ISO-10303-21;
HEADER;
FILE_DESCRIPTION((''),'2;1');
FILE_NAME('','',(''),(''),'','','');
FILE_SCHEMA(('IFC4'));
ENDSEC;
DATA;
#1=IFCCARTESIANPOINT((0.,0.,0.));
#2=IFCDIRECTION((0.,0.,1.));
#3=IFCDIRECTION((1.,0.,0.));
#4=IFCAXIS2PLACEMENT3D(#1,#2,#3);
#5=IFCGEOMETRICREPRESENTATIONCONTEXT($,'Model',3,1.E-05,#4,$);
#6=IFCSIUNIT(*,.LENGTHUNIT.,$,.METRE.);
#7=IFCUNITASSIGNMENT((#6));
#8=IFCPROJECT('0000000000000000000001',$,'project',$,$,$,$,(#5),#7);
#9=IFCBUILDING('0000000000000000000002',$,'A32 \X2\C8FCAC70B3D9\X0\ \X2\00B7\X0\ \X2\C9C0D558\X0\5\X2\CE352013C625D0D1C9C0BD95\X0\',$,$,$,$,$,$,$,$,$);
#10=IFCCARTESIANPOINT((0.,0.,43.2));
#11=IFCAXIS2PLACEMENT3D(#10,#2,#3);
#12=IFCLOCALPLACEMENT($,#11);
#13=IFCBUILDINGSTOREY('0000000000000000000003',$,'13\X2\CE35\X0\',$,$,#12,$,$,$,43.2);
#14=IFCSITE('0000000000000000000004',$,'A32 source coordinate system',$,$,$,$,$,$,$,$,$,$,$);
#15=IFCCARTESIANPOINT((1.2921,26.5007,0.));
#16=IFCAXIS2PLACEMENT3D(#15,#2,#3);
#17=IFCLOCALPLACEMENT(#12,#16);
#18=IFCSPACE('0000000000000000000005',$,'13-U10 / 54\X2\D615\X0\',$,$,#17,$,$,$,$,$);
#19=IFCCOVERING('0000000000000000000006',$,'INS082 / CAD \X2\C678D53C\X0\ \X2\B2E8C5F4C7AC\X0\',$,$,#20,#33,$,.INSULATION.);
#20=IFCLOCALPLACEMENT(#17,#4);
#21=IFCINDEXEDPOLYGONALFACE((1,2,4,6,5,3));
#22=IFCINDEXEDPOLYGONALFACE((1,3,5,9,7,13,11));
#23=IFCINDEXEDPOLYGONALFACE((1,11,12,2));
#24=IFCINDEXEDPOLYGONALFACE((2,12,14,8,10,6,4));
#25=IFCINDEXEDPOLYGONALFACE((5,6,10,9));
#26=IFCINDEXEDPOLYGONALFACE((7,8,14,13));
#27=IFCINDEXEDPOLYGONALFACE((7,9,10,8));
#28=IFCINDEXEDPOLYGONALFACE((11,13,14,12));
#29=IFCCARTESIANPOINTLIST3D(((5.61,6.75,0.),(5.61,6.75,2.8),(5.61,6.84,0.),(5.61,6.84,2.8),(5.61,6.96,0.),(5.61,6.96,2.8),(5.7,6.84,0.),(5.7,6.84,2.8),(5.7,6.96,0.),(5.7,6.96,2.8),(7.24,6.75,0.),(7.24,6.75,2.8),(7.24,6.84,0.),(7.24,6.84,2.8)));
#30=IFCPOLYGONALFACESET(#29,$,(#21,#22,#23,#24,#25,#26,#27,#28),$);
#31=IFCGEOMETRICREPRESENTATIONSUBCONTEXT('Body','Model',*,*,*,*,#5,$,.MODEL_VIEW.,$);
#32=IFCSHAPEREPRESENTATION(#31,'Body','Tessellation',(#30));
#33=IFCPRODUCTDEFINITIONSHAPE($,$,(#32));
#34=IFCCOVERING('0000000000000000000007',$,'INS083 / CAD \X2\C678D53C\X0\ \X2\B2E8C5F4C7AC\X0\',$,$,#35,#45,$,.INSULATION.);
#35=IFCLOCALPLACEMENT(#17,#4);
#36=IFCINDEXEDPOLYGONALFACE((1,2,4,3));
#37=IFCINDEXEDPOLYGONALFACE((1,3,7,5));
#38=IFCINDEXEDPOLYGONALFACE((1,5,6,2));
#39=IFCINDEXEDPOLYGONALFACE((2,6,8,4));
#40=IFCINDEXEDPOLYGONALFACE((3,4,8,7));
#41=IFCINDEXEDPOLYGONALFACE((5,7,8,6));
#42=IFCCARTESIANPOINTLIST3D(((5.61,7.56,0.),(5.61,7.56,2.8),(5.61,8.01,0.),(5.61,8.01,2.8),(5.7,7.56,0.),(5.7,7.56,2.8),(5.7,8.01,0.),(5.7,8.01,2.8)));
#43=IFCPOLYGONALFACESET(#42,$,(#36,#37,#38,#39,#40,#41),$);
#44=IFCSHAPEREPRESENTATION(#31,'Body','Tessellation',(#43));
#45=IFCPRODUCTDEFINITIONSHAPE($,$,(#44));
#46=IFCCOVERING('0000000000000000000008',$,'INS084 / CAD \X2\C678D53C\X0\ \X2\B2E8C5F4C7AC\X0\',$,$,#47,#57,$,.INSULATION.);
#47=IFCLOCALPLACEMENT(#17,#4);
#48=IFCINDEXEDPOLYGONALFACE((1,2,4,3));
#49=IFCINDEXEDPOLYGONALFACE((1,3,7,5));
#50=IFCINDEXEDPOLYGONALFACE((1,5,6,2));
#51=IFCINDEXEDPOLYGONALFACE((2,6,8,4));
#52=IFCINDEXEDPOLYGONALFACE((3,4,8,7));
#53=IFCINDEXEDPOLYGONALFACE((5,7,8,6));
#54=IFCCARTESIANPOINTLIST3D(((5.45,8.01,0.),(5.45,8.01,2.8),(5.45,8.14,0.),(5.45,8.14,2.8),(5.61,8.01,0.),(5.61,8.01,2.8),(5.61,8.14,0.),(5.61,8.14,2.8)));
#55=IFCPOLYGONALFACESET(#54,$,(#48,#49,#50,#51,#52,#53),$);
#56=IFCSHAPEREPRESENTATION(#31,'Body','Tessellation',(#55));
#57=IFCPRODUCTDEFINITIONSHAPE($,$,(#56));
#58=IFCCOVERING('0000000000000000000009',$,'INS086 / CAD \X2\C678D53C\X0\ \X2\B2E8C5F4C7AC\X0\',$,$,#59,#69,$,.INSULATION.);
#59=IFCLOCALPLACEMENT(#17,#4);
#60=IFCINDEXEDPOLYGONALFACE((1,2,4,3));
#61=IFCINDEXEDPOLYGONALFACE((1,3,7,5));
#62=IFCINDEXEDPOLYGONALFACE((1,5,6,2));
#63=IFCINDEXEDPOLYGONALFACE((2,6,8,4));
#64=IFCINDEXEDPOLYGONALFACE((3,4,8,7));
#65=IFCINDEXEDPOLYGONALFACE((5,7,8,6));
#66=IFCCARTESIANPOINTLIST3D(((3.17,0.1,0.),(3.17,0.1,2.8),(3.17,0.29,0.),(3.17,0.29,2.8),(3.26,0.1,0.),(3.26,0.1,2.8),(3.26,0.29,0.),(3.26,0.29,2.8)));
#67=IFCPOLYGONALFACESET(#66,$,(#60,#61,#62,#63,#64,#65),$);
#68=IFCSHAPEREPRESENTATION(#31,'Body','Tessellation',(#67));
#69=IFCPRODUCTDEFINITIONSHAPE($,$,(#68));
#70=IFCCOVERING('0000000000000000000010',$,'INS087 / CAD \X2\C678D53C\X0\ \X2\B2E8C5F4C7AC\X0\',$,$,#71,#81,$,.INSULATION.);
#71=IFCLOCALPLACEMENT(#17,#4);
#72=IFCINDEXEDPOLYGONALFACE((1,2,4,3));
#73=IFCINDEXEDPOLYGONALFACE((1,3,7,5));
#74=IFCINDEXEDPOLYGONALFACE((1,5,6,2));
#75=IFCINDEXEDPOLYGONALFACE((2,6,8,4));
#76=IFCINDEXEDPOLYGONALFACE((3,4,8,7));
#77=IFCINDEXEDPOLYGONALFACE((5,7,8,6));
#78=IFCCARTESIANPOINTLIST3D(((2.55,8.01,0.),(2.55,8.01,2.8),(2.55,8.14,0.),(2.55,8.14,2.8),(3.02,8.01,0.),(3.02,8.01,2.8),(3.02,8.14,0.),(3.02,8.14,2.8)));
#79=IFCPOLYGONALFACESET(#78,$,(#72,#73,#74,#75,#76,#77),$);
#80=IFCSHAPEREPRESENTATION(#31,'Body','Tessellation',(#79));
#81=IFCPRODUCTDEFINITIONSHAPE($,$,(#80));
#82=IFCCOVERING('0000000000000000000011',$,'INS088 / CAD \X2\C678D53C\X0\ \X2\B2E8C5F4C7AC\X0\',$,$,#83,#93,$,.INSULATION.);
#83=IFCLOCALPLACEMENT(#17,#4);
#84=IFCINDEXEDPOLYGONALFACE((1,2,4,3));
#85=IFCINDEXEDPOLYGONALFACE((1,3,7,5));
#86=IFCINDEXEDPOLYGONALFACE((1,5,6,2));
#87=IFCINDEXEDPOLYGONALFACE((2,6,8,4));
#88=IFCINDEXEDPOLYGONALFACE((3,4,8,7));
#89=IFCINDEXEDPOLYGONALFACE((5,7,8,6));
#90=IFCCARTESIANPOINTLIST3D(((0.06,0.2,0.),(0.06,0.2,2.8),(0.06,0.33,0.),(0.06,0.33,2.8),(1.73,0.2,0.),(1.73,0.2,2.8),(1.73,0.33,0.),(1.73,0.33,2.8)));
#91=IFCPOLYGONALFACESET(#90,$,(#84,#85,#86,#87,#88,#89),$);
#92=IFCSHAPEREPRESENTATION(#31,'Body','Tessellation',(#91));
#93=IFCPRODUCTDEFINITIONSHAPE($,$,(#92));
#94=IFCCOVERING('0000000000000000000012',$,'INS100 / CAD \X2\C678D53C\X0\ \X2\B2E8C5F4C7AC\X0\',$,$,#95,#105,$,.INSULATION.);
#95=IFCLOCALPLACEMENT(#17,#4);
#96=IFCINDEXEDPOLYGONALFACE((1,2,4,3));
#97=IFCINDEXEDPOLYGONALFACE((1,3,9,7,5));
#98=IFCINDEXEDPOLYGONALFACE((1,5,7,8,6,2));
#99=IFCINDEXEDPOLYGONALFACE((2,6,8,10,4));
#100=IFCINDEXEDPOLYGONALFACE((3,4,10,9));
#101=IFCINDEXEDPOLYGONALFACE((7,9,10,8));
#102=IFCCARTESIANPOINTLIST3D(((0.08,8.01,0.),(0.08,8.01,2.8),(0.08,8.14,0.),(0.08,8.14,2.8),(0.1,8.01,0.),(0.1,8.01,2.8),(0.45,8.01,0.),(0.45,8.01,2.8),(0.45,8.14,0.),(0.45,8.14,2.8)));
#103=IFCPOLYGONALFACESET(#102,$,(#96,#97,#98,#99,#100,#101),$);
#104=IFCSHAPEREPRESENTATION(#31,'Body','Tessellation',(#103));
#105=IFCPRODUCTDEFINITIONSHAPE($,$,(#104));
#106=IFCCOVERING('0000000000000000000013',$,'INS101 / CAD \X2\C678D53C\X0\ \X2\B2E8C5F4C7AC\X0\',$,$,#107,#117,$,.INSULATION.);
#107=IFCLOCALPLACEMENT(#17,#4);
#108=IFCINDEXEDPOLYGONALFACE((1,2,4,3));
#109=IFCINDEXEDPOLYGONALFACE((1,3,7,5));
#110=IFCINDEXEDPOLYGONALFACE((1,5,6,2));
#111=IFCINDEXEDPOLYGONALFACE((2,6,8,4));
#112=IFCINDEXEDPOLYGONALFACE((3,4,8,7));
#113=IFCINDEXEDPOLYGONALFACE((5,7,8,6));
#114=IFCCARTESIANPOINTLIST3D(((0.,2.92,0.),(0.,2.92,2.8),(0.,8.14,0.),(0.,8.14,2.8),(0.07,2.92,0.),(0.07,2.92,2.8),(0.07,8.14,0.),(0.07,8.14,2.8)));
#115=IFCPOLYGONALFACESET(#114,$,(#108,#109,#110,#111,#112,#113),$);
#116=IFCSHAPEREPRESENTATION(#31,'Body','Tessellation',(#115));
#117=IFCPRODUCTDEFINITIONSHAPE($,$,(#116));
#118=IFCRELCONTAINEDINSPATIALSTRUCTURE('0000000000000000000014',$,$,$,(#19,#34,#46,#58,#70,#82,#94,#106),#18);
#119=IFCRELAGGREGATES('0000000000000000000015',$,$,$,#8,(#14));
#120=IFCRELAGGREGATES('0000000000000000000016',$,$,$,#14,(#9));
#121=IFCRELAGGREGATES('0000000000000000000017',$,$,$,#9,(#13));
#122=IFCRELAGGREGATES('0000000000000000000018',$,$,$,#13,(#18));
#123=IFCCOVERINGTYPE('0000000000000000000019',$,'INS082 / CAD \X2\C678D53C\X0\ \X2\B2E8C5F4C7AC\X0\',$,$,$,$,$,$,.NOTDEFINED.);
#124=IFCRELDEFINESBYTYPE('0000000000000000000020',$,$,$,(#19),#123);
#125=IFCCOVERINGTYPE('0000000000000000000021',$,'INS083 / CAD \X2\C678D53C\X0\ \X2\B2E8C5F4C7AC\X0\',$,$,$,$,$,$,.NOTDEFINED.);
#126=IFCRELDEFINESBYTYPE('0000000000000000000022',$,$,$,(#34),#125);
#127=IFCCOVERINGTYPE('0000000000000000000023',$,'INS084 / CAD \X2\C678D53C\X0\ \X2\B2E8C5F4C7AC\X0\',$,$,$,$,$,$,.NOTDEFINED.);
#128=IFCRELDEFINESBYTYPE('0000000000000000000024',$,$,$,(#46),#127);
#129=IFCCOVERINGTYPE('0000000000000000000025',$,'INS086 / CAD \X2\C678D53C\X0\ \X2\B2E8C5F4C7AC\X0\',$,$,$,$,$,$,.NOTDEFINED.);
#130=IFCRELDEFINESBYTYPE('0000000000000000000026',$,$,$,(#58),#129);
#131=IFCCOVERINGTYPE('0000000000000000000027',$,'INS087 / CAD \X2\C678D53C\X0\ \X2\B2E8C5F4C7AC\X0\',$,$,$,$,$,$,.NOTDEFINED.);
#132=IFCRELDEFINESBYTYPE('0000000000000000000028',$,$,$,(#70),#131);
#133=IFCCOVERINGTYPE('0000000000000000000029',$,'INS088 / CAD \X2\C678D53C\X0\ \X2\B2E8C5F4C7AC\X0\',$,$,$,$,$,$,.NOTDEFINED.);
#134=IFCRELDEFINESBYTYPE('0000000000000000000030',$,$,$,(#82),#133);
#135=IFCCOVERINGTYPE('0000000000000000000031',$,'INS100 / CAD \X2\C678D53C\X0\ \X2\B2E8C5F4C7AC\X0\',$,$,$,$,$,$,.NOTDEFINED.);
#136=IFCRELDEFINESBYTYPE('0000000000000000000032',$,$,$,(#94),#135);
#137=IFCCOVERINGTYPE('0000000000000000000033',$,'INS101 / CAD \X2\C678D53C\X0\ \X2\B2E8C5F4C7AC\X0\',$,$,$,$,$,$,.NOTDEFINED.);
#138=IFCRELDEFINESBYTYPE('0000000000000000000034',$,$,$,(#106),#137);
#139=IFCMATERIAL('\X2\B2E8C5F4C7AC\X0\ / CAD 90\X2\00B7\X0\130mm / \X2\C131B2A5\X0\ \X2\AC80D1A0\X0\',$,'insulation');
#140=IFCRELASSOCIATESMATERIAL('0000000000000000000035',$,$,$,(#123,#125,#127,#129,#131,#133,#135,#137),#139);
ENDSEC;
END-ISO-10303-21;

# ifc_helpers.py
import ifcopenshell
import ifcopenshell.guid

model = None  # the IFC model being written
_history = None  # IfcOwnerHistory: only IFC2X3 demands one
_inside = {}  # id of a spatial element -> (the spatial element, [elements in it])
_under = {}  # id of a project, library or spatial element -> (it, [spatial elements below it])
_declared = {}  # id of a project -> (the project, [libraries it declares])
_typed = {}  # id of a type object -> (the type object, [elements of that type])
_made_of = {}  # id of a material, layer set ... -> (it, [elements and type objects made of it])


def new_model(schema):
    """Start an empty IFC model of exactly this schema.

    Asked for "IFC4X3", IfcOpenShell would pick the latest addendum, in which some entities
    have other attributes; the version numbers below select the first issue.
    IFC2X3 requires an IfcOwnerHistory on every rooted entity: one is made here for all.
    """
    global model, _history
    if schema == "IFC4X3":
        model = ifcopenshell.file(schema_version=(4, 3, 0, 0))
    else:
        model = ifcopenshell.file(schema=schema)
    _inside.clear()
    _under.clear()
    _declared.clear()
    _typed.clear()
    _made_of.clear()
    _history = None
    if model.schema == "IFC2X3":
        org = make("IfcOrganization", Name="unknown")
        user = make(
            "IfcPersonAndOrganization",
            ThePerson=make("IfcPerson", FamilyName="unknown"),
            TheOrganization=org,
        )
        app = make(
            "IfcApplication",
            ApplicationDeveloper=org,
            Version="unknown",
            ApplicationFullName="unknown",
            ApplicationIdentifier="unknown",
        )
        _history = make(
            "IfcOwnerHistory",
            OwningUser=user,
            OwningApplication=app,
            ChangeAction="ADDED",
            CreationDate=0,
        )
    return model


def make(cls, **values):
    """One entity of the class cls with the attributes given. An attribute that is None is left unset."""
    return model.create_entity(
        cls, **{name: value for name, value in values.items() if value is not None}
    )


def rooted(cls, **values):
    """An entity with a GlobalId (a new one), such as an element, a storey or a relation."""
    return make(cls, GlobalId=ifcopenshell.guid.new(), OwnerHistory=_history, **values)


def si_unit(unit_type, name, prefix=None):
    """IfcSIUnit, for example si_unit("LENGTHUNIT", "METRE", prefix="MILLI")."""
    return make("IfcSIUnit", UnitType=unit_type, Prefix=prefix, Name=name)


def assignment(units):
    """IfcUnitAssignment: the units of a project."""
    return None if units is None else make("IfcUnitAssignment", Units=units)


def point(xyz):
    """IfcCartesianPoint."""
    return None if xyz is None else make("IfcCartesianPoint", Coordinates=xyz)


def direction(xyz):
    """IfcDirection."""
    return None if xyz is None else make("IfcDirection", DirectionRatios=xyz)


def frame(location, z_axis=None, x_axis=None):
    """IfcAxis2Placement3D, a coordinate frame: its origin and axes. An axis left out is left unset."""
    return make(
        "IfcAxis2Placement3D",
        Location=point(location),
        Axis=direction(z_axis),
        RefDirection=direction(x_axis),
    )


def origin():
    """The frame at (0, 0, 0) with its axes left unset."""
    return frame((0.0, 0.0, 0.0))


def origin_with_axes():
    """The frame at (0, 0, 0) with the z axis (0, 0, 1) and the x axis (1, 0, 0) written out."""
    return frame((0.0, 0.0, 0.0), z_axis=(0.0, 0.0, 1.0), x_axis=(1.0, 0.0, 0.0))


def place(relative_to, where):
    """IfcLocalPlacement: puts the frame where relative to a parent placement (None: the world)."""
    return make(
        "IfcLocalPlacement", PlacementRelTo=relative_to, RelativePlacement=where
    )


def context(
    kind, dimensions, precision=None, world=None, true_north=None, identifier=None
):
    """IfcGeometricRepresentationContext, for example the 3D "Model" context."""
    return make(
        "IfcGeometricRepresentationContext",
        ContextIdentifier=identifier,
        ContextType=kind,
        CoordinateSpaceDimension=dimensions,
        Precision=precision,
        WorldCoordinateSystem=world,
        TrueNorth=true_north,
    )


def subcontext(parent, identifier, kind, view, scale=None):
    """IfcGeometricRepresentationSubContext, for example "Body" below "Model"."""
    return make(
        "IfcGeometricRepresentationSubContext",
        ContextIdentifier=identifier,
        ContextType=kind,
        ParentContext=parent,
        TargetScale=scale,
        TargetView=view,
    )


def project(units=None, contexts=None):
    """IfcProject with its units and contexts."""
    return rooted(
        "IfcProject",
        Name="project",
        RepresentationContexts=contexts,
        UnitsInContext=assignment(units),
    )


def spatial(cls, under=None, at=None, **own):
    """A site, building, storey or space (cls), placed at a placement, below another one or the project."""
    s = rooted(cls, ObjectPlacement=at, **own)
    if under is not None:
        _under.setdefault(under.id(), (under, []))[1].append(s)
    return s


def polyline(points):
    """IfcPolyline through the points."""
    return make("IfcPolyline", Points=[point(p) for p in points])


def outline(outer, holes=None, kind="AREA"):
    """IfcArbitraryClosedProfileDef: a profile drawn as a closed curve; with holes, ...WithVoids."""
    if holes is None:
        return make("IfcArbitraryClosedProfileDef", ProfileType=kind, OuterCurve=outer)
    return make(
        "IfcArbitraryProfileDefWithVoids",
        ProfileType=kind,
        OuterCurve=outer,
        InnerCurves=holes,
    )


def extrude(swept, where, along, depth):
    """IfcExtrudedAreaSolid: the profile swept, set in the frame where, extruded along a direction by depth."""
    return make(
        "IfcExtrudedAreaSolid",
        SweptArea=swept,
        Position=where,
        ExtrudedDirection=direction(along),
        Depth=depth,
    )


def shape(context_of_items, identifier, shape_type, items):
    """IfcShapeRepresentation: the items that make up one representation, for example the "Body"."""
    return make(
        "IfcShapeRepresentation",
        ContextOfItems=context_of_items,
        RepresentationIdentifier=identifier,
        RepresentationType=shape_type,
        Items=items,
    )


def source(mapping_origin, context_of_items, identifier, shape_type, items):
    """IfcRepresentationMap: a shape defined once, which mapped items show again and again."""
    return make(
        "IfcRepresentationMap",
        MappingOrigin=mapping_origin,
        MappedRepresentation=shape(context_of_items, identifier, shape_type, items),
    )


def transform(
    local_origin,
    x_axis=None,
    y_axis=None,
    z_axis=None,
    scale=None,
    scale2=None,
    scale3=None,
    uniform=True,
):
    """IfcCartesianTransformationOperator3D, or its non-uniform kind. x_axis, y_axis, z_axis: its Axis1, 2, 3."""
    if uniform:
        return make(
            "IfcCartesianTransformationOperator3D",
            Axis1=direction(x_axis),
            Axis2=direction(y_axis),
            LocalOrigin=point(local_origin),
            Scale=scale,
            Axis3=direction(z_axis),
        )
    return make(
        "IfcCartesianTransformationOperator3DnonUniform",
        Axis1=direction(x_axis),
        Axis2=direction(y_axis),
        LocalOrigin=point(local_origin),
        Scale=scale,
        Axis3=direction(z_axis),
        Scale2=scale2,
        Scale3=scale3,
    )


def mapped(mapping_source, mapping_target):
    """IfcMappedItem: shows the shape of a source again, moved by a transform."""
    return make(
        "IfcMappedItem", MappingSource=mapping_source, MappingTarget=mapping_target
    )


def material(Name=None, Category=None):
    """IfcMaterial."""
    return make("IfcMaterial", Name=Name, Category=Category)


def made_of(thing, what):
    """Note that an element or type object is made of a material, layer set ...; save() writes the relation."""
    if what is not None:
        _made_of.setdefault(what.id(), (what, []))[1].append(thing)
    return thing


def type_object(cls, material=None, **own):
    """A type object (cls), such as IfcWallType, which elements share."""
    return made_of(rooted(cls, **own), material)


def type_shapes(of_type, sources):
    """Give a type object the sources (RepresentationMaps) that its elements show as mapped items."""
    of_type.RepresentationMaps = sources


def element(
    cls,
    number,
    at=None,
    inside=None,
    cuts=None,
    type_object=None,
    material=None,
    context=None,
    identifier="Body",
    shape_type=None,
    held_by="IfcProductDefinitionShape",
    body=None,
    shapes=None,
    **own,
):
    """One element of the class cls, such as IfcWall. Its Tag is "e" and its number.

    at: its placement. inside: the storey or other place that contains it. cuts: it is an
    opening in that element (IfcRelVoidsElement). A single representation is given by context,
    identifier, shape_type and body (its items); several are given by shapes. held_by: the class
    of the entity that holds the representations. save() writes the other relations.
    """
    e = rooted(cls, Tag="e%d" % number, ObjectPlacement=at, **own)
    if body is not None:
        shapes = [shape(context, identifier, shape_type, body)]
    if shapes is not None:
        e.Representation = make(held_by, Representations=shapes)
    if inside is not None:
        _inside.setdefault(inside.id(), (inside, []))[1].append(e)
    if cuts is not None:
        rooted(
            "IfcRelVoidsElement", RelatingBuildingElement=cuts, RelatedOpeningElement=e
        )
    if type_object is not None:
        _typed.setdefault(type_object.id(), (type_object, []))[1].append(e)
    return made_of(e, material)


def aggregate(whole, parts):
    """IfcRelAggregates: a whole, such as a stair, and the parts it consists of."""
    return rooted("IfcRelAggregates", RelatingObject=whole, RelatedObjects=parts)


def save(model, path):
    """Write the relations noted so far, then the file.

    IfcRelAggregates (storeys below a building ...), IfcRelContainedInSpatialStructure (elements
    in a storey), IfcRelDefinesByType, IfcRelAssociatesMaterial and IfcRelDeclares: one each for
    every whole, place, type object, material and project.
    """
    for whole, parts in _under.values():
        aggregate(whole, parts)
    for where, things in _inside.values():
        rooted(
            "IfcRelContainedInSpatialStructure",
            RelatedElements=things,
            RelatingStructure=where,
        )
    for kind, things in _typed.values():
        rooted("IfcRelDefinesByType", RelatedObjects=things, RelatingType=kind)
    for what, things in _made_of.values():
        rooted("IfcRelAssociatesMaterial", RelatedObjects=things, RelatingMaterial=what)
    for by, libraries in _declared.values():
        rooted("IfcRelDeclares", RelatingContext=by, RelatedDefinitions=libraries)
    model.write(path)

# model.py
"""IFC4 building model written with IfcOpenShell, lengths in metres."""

from ifc_helpers import new_model, si_unit, frame, origin, origin_with_axes, place, context, subcontext, project, spatial, polyline, outline, extrude, source, transform, mapped, material, type_object, type_shapes, element, save


model = new_model("IFC4")

# Units and contexts
model_context = context("Model", 3, precision=1e-05, world=origin_with_axes())
body_context = subcontext(model_context, "Body", "Model", "MODEL_VIEW")
ifc_project = project(units=[si_unit("LENGTHUNIT", "METRE")], contexts=[model_context])

# Site, building, storey, space
storey_placement = place(None, frame((0.0, 0.0, 43.2), z_axis=(0.0, 0.0, 1.0), x_axis=(1.0, 0.0, 0.0)))
space_placement = place(storey_placement, frame((1.2921, 26.5007, 0.0), z_axis=(0.0, 0.0, 1.0), x_axis=(1.0, 0.0, 0.0)))
site = spatial("IfcSite", under=ifc_project, Name="A32 source coordinate system")
building = spatial("IfcBuilding", under=site, Name="A32 주거동 · 지하5층–옥탑지붕")
storey = spatial("IfcBuildingStorey", under=building, at=storey_placement, Name="13층", Elevation=43.2)
space = spatial("IfcSpace", under=storey, at=space_placement, Name="13-U10 / 54형")

# Coverings
ifc_material = material(Name="단열재 / CAD 90·130mm / 성능 검토", Category="insulation")
covering_type_1 = type_object("IfcCoveringType", Name="INS082 / CAD 외피 단열재", PredefinedType="NOTDEFINED", material=ifc_material)
shared_shape_1 = source(origin(), body_context, "Body", "SweptSolid", [
    extrude(outline(polyline([(5.61, 6.84), (5.61, 6.96), (5.7, 6.96), (5.7, 6.84), (7.24, 6.84), (7.24, 6.75), (5.61, 6.75), (5.61, 6.84)])), origin(), (0.0, 0.0, 1.0), 2.8),
])
type_shapes(covering_type_1, [shared_shape_1])
covering_1_placement = place(space_placement, origin_with_axes())
element("IfcCovering", 1, at=covering_1_placement, inside=space, type_object=covering_type_1, Name="INS082 / CAD 외피 단열재", PredefinedType="INSULATION", context=body_context, shape_type="MappedRepresentation", body=[
    mapped(shared_shape_1, transform((0.0, 0.0, 0.0), scale=1.0)),
])
covering_type_2 = type_object("IfcCoveringType", Name="INS083 / CAD 외피 단열재", PredefinedType="NOTDEFINED", material=ifc_material)
shared_shape_2 = source(origin(), body_context, "Body", "SweptSolid", [
    extrude(outline(polyline([(5.61, 8.01), (5.7, 8.01), (5.7, 7.56), (5.61, 7.56), (5.61, 8.01)])), origin(), (0.0, 0.0, 1.0), 2.8),
])
type_shapes(covering_type_2, [shared_shape_2])
covering_2_placement = place(space_placement, origin_with_axes())
element("IfcCovering", 2, at=covering_2_placement, inside=space, type_object=covering_type_2, Name="INS083 / CAD 외피 단열재", PredefinedType="INSULATION", context=body_context, shape_type="MappedRepresentation", body=[
    mapped(shared_shape_2, transform((0.0, 0.0, 0.0), scale=1.0)),
])
covering_type_3 = type_object("IfcCoveringType", Name="INS084 / CAD 외피 단열재", PredefinedType="NOTDEFINED", material=ifc_material)
shared_shape_3 = source(origin(), body_context, "Body", "SweptSolid", [
    extrude(outline(polyline([(5.45, 8.01), (5.45, 8.14), (5.61, 8.14), (5.61, 8.01), (5.45, 8.01)])), origin(), (0.0, 0.0, 1.0), 2.8),
])
type_shapes(covering_type_3, [shared_shape_3])
covering_3_placement = place(space_placement, origin_with_axes())
element("IfcCovering", 3, at=covering_3_placement, inside=space, type_object=covering_type_3, Name="INS084 / CAD 외피 단열재", PredefinedType="INSULATION", context=body_context, shape_type="MappedRepresentation", body=[
    mapped(shared_shape_3, transform((0.0, 0.0, 0.0), scale=1.0)),
])
covering_type_4 = type_object("IfcCoveringType", Name="INS086 / CAD 외피 단열재", PredefinedType="NOTDEFINED", material=ifc_material)
shared_shape_4 = source(origin(), body_context, "Body", "SweptSolid", [
    extrude(outline(polyline([(3.17, 0.1), (3.17, 0.29), (3.26, 0.29), (3.26, 0.1), (3.17, 0.1)])), origin(), (0.0, 0.0, 1.0), 2.8),
])
type_shapes(covering_type_4, [shared_shape_4])
covering_4_placement = place(space_placement, origin_with_axes())
element("IfcCovering", 4, at=covering_4_placement, inside=space, type_object=covering_type_4, Name="INS086 / CAD 외피 단열재", PredefinedType="INSULATION", context=body_context, shape_type="MappedRepresentation", body=[
    mapped(shared_shape_4, transform((0.0, 0.0, 0.0), scale=1.0)),
])
covering_type_5 = type_object("IfcCoveringType", Name="INS087 / CAD 외피 단열재", PredefinedType="NOTDEFINED", material=ifc_material)
shared_shape_5 = source(origin(), body_context, "Body", "SweptSolid", [
    extrude(outline(polyline([(2.55, 8.14), (3.02, 8.14), (3.02, 8.01), (2.55, 8.01), (2.55, 8.14)])), origin(), (0.0, 0.0, 1.0), 2.8),
])
type_shapes(covering_type_5, [shared_shape_5])
covering_5_placement = place(space_placement, origin_with_axes())
element("IfcCovering", 5, at=covering_5_placement, inside=space, type_object=covering_type_5, Name="INS087 / CAD 외피 단열재", PredefinedType="INSULATION", context=body_context, shape_type="MappedRepresentation", body=[
    mapped(shared_shape_5, transform((0.0, 0.0, 0.0), scale=1.0)),
])
covering_type_6 = type_object("IfcCoveringType", Name="INS088 / CAD 외피 단열재", PredefinedType="NOTDEFINED", material=ifc_material)
shared_shape_6 = source(origin(), body_context, "Body", "SweptSolid", [
    extrude(outline(polyline([(0.06, 0.33), (1.73, 0.33), (1.73, 0.2), (0.06, 0.2), (0.06, 0.33)])), origin(), (0.0, 0.0, 1.0), 2.8),
])
type_shapes(covering_type_6, [shared_shape_6])
covering_6_placement = place(space_placement, origin_with_axes())
element("IfcCovering", 6, at=covering_6_placement, inside=space, type_object=covering_type_6, Name="INS088 / CAD 외피 단열재", PredefinedType="INSULATION", context=body_context, shape_type="MappedRepresentation", body=[
    mapped(shared_shape_6, transform((0.0, 0.0, 0.0), scale=1.0)),
])
covering_type_7 = type_object("IfcCoveringType", Name="INS100 / CAD 외피 단열재", PredefinedType="NOTDEFINED", material=ifc_material)
shared_shape_7 = source(origin(), body_context, "Body", "SweptSolid", [
    extrude(outline(polyline([(0.08, 8.01), (0.08, 8.14), (0.45, 8.14), (0.45, 8.01), (0.1, 8.01), (0.08, 8.01)])), origin(), (0.0, 0.0, 1.0), 2.8),
])
type_shapes(covering_type_7, [shared_shape_7])
covering_7_placement = place(space_placement, origin_with_axes())
element("IfcCovering", 7, at=covering_7_placement, inside=space, type_object=covering_type_7, Name="INS100 / CAD 외피 단열재", PredefinedType="INSULATION", context=body_context, shape_type="MappedRepresentation", body=[
    mapped(shared_shape_7, transform((0.0, 0.0, 0.0), scale=1.0)),
])
covering_type_8 = type_object("IfcCoveringType", Name="INS101 / CAD 외피 단열재", PredefinedType="NOTDEFINED", material=ifc_material)
shared_shape_8 = source(origin(), body_context, "Body", "SweptSolid", [
    extrude(outline(polyline([(0.0, 2.92), (0.0, 8.14), (0.07, 8.14), (0.07, 2.92), (0.0, 2.92)])), origin(), (0.0, 0.0, 1.0), 2.8),
])
type_shapes(covering_type_8, [shared_shape_8])
covering_8_placement = place(space_placement, origin_with_axes())
element("IfcCovering", 8, at=covering_8_placement, inside=space, type_object=covering_type_8, Name="INS101 / CAD 외피 단열재", PredefinedType="INSULATION", context=body_context, shape_type="MappedRepresentation", body=[
    mapped(shared_shape_8, transform((0.0, 0.0, 0.0), scale=1.0)),
])

save(model, "model.ifc")
